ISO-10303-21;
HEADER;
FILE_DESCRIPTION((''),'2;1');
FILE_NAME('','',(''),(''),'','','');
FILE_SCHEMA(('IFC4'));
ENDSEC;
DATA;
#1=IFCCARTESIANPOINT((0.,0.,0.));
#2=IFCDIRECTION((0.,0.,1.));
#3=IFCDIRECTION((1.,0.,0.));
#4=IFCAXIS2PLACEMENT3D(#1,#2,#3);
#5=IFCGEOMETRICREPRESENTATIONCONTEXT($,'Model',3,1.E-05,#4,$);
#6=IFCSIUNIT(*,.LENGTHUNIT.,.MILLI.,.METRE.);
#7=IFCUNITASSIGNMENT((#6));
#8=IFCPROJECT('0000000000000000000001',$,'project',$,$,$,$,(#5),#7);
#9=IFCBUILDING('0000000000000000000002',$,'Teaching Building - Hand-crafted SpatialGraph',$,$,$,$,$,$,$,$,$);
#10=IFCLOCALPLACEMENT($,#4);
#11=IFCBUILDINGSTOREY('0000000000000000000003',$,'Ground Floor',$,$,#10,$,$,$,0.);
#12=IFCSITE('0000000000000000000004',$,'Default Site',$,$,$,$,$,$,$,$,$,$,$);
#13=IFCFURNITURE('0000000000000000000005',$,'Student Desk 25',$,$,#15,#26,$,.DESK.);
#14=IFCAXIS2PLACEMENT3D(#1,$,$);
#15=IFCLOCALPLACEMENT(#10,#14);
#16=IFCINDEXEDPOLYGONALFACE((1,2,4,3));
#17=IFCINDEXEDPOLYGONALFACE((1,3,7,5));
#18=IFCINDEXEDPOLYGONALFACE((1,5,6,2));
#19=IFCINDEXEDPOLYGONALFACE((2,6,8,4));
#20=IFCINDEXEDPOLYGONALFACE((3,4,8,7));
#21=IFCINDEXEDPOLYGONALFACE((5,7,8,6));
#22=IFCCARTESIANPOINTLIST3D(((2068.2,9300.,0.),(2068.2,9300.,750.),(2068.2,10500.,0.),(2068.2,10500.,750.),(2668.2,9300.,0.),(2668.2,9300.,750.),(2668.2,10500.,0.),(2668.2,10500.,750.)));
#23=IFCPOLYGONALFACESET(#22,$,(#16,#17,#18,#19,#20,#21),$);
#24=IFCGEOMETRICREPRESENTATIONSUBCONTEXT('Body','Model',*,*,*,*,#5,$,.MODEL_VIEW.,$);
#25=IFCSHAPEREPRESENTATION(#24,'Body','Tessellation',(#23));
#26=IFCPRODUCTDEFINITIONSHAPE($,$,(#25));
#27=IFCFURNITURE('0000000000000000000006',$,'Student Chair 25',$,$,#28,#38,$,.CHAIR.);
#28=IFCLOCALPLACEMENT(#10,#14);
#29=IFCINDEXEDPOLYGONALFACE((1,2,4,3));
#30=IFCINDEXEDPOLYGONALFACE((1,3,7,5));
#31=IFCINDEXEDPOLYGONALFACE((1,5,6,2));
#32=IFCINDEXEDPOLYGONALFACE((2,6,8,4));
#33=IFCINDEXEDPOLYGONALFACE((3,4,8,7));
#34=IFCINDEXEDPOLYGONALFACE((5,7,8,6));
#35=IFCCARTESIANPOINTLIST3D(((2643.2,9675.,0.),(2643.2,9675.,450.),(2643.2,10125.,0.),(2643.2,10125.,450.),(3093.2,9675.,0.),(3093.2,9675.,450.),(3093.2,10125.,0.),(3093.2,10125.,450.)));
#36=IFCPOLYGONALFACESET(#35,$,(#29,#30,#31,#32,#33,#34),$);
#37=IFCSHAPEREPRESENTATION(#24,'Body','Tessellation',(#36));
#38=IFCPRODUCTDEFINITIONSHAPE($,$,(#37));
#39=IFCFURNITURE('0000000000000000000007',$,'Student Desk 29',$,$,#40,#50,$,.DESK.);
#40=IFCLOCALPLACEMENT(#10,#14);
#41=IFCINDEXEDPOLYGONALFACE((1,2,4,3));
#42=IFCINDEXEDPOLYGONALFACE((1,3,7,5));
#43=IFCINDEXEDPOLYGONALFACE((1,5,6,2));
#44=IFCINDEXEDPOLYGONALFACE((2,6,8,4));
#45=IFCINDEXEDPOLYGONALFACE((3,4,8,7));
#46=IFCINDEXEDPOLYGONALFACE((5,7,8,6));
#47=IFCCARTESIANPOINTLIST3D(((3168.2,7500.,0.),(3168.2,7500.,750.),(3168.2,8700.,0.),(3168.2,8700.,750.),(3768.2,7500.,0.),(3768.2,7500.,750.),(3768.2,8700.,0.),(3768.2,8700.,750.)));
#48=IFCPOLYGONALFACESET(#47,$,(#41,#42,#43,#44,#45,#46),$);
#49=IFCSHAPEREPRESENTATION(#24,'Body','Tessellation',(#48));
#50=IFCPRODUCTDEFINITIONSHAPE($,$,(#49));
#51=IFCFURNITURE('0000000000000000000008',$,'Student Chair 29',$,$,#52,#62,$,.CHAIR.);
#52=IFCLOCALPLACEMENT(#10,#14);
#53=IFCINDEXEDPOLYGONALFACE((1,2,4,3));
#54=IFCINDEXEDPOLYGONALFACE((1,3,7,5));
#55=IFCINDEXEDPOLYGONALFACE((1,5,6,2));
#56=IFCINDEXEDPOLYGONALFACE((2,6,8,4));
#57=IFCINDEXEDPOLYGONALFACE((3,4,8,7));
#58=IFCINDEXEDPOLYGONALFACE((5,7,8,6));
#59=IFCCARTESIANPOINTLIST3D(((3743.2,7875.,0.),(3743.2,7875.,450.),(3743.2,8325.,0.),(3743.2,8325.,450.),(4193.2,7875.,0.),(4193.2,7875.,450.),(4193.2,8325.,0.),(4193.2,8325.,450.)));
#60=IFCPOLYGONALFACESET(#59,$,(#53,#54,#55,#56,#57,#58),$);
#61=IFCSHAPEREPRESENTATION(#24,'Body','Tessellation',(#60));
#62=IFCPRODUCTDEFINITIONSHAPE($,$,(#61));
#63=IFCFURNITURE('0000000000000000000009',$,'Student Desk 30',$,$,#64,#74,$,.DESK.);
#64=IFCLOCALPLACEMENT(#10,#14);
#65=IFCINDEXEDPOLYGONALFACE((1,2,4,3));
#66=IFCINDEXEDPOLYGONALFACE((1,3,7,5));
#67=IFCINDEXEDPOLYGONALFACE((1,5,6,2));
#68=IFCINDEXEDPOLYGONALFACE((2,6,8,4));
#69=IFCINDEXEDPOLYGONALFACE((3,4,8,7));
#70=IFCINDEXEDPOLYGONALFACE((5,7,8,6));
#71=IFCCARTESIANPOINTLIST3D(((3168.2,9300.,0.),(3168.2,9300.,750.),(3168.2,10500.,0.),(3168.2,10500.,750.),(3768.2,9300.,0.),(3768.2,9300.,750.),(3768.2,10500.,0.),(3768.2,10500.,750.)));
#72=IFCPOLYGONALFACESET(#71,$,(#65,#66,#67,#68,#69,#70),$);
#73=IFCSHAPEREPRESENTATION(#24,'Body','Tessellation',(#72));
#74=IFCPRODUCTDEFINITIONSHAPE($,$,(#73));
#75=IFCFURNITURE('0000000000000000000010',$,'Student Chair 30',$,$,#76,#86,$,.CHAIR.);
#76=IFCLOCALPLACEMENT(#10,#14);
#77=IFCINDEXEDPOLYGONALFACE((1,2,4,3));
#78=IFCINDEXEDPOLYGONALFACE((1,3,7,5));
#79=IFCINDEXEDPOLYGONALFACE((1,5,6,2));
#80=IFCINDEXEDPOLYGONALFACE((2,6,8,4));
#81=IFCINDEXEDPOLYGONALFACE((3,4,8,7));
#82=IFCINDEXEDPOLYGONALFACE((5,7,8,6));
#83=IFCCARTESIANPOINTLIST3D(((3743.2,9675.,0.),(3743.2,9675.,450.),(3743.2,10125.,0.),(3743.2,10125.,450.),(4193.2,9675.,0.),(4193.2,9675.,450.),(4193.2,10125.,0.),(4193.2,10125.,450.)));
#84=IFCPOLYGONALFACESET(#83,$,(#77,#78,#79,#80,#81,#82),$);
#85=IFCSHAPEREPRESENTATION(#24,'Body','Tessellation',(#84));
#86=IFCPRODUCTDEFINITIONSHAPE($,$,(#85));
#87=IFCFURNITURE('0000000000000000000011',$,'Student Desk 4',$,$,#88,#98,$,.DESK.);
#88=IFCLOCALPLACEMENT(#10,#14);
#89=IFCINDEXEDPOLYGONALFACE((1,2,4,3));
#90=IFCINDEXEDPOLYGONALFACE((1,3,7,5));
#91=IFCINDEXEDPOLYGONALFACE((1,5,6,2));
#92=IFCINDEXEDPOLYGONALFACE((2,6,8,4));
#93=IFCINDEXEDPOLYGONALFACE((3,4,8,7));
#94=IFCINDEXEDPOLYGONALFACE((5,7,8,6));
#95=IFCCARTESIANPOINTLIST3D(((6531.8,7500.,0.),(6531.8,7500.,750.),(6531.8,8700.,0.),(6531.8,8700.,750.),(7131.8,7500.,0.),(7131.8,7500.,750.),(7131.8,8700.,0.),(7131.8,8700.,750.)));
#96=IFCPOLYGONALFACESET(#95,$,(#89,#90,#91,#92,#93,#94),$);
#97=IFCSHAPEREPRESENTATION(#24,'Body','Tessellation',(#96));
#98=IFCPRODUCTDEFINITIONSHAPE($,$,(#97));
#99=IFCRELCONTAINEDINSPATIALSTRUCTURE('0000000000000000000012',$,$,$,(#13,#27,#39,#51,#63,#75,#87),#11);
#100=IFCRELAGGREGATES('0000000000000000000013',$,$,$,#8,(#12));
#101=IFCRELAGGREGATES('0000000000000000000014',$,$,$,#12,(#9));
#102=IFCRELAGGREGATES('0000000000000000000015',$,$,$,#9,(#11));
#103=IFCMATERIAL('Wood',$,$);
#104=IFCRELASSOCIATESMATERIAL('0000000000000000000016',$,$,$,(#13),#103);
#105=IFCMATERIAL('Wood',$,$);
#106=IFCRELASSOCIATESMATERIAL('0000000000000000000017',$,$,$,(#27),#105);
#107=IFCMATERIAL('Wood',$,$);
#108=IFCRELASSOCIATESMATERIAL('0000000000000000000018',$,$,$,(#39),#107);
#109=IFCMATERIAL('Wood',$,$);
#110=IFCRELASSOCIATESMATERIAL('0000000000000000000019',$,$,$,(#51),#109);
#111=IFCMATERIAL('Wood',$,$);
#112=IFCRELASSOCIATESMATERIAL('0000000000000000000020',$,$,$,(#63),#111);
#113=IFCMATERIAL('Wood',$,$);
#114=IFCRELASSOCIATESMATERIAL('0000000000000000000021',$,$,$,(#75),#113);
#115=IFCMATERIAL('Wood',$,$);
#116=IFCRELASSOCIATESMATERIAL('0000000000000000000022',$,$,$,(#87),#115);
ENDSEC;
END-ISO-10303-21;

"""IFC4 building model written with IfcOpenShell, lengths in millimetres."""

from ifc_helpers import new_model, si_unit, frame, origin_with_axes, origin_2d, place, context, subcontext, project, spatial, rectangle, extrude, material, element, save


model = new_model("IFC4")

# Units and contexts
model_context = context("Model", 3, precision=1e-05, world=origin_with_axes())
body_context = subcontext(model_context, "Body", "Model", "MODEL_VIEW")
ifc_project = project(units=[si_unit("LENGTHUNIT", "METRE", prefix="MILLI")], contexts=[model_context])

# Site, building, storey
site = spatial("IfcSite", under=ifc_project, Name="Default Site")
building = spatial("IfcBuilding", under=site, Name="Teaching Building - Hand-crafted SpatialGraph")
storey_placement = place(None, origin_with_axes())
storey = spatial("IfcBuildingStorey", under=building, at=storey_placement, Name="Ground Floor", Elevation=0.0)

# Furniture
ifc_material_1 = material(Name="Wood")
furniture_1_placement = place(storey_placement, frame((2368.2, 9900.0, 0.0), z_axis=(0.0, 0.0, 1.0), x_axis=(0.0, 1.0, 0.0)))
element("IfcFurniture", 1, at=furniture_1_placement, inside=storey, material=ifc_material_1, Name="Student Desk 25", PredefinedType="DESK", context=body_context, shape_type="SweptSolid", body=[
    extrude(rectangle(XDim=1200.0, YDim=600.0, at=origin_2d()), origin_with_axes(), (0.0, 0.0, 1.0), 750.0),
])
ifc_material_2 = material(Name="Wood")
furniture_2_placement = place(storey_placement, frame((2868.2, 9900.0, 0.0), z_axis=(0.0, 0.0, 1.0), x_axis=(1.0, 0.0, 0.0)))
element("IfcFurniture", 2, at=furniture_2_placement, inside=storey, material=ifc_material_2, Name="Student Chair 25", PredefinedType="CHAIR", context=body_context, shape_type="SweptSolid", body=[
    extrude(rectangle(XDim=450.0, YDim=450.0, at=origin_2d()), origin_with_axes(), (0.0, 0.0, 1.0), 450.0),
])
ifc_material_3 = material(Name="Wood")
furniture_3_placement = place(storey_placement, frame((3468.2, 8100.0, 0.0), z_axis=(0.0, 0.0, 1.0), x_axis=(0.0, 1.0, 0.0)))
element("IfcFurniture", 3, at=furniture_3_placement, inside=storey, material=ifc_material_3, Name="Student Desk 29", PredefinedType="DESK", context=body_context, shape_type="SweptSolid", body=[
    extrude(rectangle(XDim=1200.0, YDim=600.0, at=origin_2d()), origin_with_axes(), (0.0, 0.0, 1.0), 750.0),
])
ifc_material_4 = material(Name="Wood")
furniture_4_placement = place(storey_placement, frame((3968.2, 8100.0, 0.0), z_axis=(0.0, 0.0, 1.0), x_axis=(1.0, 0.0, 0.0)))
element("IfcFurniture", 4, at=furniture_4_placement, inside=storey, material=ifc_material_4, Name="Student Chair 29", PredefinedType="CHAIR", context=body_context, shape_type="SweptSolid", body=[
    extrude(rectangle(XDim=450.0, YDim=450.0, at=origin_2d()), origin_with_axes(), (0.0, 0.0, 1.0), 450.0),
])
ifc_material_5 = material(Name="Wood")
furniture_5_placement = place(storey_placement, frame((3468.2, 9900.0, 0.0), z_axis=(0.0, 0.0, 1.0), x_axis=(0.0, 1.0, 0.0)))
element("IfcFurniture", 5, at=furniture_5_placement, inside=storey, material=ifc_material_5, Name="Student Desk 30", PredefinedType="DESK", context=body_context, shape_type="SweptSolid", body=[
    extrude(rectangle(XDim=1200.0, YDim=600.0, at=origin_2d()), origin_with_axes(), (0.0, 0.0, 1.0), 750.0),
])
ifc_material_6 = material(Name="Wood")
furniture_6_placement = place(storey_placement, frame((3968.2, 9900.0, 0.0), z_axis=(0.0, 0.0, 1.0), x_axis=(1.0, 0.0, 0.0)))
element("IfcFurniture", 6, at=furniture_6_placement, inside=storey, material=ifc_material_6, Name="Student Chair 30", PredefinedType="CHAIR", context=body_context, shape_type="SweptSolid", body=[
    extrude(rectangle(XDim=450.0, YDim=450.0, at=origin_2d()), origin_with_axes(), (0.0, 0.0, 1.0), 450.0),
])
ifc_material_7 = material(Name="Wood")
furniture_7_placement = place(storey_placement, frame((6831.8, 8100.0, 0.0), z_axis=(0.0, 0.0, 1.0), x_axis=(0.0, 1.0, 0.0)))
element("IfcFurniture", 7, at=furniture_7_placement, inside=storey, material=ifc_material_7, Name="Student Desk 4", PredefinedType="DESK", context=body_context, shape_type="SweptSolid", body=[
    extrude(rectangle(XDim=1200.0, YDim=600.0, at=origin_2d()), origin_with_axes(), (0.0, 0.0, 1.0), 750.0),
])

save(model, "model.ifc")
